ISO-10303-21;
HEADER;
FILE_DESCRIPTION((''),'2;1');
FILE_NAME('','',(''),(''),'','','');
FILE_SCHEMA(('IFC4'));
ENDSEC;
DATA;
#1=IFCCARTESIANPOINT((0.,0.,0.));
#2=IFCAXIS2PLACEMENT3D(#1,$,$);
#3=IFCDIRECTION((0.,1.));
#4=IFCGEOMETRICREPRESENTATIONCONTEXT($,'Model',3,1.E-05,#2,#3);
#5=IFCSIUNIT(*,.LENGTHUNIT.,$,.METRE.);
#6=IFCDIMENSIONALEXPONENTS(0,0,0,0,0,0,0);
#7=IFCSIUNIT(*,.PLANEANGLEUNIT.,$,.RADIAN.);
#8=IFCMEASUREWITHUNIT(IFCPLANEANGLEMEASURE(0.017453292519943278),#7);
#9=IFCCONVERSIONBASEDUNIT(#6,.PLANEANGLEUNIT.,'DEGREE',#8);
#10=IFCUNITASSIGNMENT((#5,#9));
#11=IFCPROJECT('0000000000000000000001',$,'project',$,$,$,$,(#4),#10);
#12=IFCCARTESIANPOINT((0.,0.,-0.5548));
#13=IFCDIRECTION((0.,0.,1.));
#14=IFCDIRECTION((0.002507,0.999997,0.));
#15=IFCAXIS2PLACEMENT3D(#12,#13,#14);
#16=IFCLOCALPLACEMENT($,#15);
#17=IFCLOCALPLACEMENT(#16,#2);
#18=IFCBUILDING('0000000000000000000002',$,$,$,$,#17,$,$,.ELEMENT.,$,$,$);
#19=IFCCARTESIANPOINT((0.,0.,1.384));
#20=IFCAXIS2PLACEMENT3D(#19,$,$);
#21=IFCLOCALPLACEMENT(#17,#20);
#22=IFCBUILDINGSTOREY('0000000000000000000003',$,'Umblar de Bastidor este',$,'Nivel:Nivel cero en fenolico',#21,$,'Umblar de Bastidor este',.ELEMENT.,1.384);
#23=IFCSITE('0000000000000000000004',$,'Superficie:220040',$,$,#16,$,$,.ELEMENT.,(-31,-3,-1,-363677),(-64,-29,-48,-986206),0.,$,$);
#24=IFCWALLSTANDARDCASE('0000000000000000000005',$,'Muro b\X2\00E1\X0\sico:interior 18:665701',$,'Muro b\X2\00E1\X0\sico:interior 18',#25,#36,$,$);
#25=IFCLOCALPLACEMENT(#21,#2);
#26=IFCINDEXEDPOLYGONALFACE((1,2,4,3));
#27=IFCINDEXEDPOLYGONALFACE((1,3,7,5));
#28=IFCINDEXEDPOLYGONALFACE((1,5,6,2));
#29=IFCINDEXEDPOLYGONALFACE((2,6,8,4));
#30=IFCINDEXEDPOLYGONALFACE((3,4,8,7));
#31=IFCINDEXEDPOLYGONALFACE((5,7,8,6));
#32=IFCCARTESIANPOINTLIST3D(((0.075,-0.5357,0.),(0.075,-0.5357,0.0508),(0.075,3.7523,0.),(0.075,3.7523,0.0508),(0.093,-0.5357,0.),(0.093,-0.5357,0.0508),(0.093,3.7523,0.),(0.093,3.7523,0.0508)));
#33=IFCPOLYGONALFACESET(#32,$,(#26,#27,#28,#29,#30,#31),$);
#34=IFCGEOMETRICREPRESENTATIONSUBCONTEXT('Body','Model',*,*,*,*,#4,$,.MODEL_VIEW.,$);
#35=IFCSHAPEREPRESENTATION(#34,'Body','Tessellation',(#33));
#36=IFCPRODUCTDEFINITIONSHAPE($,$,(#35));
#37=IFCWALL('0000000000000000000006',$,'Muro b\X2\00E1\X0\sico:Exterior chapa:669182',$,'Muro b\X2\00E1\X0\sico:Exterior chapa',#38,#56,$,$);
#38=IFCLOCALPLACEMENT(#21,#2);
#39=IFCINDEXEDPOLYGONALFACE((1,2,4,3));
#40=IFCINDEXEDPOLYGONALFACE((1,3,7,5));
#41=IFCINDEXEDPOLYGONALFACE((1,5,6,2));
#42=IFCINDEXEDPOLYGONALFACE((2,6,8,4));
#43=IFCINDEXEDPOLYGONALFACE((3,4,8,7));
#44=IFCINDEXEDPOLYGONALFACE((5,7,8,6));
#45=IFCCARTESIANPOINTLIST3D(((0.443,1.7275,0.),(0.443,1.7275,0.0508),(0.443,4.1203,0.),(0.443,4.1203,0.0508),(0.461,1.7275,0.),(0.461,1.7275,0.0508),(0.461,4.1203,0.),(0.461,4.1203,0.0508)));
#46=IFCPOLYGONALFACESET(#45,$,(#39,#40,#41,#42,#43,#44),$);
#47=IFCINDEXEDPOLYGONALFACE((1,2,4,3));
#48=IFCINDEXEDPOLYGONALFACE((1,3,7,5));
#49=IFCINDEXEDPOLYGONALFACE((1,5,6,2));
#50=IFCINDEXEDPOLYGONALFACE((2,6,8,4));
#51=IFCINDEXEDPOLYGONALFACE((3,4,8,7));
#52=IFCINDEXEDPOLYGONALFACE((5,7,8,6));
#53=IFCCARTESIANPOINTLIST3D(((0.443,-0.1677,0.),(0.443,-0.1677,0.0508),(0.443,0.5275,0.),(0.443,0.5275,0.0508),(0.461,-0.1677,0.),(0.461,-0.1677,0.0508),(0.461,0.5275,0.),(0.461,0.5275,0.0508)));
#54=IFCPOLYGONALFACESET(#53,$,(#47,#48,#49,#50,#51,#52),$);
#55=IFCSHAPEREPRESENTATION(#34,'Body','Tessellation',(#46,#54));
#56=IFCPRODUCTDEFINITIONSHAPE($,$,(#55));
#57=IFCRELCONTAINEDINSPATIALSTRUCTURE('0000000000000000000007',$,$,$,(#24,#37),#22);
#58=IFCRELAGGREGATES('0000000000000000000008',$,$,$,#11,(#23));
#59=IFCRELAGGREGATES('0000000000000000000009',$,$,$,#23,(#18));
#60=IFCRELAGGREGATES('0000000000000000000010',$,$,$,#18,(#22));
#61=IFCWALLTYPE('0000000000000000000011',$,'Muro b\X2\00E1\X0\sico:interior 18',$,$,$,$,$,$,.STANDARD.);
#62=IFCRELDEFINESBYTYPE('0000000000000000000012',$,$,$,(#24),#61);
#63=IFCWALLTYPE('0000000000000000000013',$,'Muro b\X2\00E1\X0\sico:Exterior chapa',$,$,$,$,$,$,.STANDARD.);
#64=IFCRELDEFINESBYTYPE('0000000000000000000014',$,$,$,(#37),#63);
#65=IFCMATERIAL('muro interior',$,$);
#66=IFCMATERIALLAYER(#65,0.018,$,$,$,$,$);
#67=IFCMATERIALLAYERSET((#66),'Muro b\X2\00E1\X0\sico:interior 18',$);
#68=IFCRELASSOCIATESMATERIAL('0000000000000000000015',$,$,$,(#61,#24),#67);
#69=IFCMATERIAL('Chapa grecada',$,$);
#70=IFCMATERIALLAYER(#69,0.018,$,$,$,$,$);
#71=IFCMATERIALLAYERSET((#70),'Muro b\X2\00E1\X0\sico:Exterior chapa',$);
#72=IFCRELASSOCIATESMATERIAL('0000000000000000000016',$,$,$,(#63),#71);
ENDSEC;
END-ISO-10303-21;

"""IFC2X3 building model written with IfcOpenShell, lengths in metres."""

from ifc_helpers import new_model, entity, si_unit, converted_unit, direction, frame, frame_2d, origin, place, context, subcontext, project, spatial, rectangle, extrude, clip, halfspace, material, layer, layer_set, layer_usage, type_object, element, save


model = new_model("IFC2X3")

# Units and contexts
model_context = context("Model", 3, precision=1e-05, world=origin(), true_north=direction((0.0, 1.0)))
body_context = subcontext(model_context, "Body", "Model", "MODEL_VIEW")
ifc_project = project(units=[si_unit("LENGTHUNIT", "METRE"), converted_unit("PLANEANGLEUNIT", "DEGREE", entity("IfcPlaneAngleMeasure", 0.017453292519943278), si_unit("PLANEANGLEUNIT", "RADIAN"), dimensions=[0, 0, 0, 0, 0, 0, 0])], contexts=[model_context])

# Site, building, storey
site_placement = place(None, frame((0.0, 0.0, -0.5548), z_axis=(0.0, 0.0, 1.0), x_axis=(0.002507, 0.999997, 0.0)))
site = spatial("IfcSite", under=ifc_project, at=site_placement, Name="Superficie:220040", CompositionType="ELEMENT", RefLatitude=(-31, -3, -1, -363677), RefLongitude=(-64, -29, -48, -986206), RefElevation=0.0)
building_placement = place(site_placement, origin())
building = spatial("IfcBuilding", under=site, at=building_placement, CompositionType="ELEMENT")
storey_placement = place(building_placement, frame((0.0, 0.0, 1.384)))
storey = spatial("IfcBuildingStorey", under=building, at=storey_placement, Name="Umblar de Bastidor este", ObjectType="Nivel:Nivel cero en fenolico", LongName="Umblar de Bastidor este", CompositionType="ELEMENT", Elevation=1.384)

# Walls
ifc_material_1 = material(Name="muro interior")
ifc_layer_1 = layer(ifc_material_1, 0.018)
ifc_layer_set_1 = layer_set([ifc_layer_1], Name="Muro básico:interior 18")
ifc_layer_usage = layer_usage(ifc_layer_set_1, "AXIS2", "NEGATIVE", 0.009)
wall_type_1 = type_object("IfcWallType", Name="Muro básico:interior 18", PredefinedType="STANDARD", material=ifc_layer_set_1)
wall_1_placement = place(storey_placement, frame((0.084, 3.7523, 0.0), z_axis=(0.0, 0.0, 1.0), x_axis=(0.0, -1.0, 0.0)))
element("IfcWallStandardCase", 1, at=wall_1_placement, inside=storey, type_object=wall_type_1, material=ifc_layer_usage, Name="Muro básico:interior 18:665701", ObjectType="Muro básico:interior 18", context=body_context, shape_type="Clipping", body=[
    clip(extrude(rectangle(XDim=4.288, YDim=0.018, at=frame_2d((2.144, 0.0), x_axis=(-1.0, 0.0))), origin(), (0.0, 0.0, 1.0), 0.0508), halfspace(frame((0.0, 0.0, -1.3332)), True)),
])
ifc_material_2 = material(Name="Chapa grecada")
ifc_layer_2 = layer(ifc_material_2, 0.018)
ifc_layer_set_2 = layer_set([ifc_layer_2], Name="Muro básico:Exterior chapa")
wall_type_2 = type_object("IfcWallType", Name="Muro básico:Exterior chapa", PredefinedType="STANDARD", material=ifc_layer_set_2)
wall_2_placement = place(storey_placement, frame((0.452, 4.1203, 0.0), z_axis=(0.0, 0.0, 1.0), x_axis=(0.0, -1.0, 0.0)))
element("IfcWall", 2, at=wall_2_placement, inside=storey, type_object=wall_type_2, Name="Muro básico:Exterior chapa:669182", ObjectType="Muro básico:Exterior chapa", context=body_context, shape_type="SweptSolid", body=[
    extrude(rectangle(XDim=0.018, YDim=2.3928, at=frame_2d((0.0, 0.0), x_axis=(1.0, 0.0))), frame((1.1964, 0.0, 0.0), z_axis=(0.0, 0.0, 1.0), x_axis=(0.0, 1.0, 0.0)), (0.0, 0.0, 1.0), 0.0508),
    extrude(rectangle(XDim=0.018, YDim=0.6952, at=frame_2d((0.0, 0.0), x_axis=(1.0, 0.0))), frame((3.9404, 0.0, 0.0), z_axis=(0.0, 0.0, 1.0), x_axis=(0.0, 1.0, 0.0)), (0.0, 0.0, 1.0), 0.0508),
])

save(model, "model.ifc")
